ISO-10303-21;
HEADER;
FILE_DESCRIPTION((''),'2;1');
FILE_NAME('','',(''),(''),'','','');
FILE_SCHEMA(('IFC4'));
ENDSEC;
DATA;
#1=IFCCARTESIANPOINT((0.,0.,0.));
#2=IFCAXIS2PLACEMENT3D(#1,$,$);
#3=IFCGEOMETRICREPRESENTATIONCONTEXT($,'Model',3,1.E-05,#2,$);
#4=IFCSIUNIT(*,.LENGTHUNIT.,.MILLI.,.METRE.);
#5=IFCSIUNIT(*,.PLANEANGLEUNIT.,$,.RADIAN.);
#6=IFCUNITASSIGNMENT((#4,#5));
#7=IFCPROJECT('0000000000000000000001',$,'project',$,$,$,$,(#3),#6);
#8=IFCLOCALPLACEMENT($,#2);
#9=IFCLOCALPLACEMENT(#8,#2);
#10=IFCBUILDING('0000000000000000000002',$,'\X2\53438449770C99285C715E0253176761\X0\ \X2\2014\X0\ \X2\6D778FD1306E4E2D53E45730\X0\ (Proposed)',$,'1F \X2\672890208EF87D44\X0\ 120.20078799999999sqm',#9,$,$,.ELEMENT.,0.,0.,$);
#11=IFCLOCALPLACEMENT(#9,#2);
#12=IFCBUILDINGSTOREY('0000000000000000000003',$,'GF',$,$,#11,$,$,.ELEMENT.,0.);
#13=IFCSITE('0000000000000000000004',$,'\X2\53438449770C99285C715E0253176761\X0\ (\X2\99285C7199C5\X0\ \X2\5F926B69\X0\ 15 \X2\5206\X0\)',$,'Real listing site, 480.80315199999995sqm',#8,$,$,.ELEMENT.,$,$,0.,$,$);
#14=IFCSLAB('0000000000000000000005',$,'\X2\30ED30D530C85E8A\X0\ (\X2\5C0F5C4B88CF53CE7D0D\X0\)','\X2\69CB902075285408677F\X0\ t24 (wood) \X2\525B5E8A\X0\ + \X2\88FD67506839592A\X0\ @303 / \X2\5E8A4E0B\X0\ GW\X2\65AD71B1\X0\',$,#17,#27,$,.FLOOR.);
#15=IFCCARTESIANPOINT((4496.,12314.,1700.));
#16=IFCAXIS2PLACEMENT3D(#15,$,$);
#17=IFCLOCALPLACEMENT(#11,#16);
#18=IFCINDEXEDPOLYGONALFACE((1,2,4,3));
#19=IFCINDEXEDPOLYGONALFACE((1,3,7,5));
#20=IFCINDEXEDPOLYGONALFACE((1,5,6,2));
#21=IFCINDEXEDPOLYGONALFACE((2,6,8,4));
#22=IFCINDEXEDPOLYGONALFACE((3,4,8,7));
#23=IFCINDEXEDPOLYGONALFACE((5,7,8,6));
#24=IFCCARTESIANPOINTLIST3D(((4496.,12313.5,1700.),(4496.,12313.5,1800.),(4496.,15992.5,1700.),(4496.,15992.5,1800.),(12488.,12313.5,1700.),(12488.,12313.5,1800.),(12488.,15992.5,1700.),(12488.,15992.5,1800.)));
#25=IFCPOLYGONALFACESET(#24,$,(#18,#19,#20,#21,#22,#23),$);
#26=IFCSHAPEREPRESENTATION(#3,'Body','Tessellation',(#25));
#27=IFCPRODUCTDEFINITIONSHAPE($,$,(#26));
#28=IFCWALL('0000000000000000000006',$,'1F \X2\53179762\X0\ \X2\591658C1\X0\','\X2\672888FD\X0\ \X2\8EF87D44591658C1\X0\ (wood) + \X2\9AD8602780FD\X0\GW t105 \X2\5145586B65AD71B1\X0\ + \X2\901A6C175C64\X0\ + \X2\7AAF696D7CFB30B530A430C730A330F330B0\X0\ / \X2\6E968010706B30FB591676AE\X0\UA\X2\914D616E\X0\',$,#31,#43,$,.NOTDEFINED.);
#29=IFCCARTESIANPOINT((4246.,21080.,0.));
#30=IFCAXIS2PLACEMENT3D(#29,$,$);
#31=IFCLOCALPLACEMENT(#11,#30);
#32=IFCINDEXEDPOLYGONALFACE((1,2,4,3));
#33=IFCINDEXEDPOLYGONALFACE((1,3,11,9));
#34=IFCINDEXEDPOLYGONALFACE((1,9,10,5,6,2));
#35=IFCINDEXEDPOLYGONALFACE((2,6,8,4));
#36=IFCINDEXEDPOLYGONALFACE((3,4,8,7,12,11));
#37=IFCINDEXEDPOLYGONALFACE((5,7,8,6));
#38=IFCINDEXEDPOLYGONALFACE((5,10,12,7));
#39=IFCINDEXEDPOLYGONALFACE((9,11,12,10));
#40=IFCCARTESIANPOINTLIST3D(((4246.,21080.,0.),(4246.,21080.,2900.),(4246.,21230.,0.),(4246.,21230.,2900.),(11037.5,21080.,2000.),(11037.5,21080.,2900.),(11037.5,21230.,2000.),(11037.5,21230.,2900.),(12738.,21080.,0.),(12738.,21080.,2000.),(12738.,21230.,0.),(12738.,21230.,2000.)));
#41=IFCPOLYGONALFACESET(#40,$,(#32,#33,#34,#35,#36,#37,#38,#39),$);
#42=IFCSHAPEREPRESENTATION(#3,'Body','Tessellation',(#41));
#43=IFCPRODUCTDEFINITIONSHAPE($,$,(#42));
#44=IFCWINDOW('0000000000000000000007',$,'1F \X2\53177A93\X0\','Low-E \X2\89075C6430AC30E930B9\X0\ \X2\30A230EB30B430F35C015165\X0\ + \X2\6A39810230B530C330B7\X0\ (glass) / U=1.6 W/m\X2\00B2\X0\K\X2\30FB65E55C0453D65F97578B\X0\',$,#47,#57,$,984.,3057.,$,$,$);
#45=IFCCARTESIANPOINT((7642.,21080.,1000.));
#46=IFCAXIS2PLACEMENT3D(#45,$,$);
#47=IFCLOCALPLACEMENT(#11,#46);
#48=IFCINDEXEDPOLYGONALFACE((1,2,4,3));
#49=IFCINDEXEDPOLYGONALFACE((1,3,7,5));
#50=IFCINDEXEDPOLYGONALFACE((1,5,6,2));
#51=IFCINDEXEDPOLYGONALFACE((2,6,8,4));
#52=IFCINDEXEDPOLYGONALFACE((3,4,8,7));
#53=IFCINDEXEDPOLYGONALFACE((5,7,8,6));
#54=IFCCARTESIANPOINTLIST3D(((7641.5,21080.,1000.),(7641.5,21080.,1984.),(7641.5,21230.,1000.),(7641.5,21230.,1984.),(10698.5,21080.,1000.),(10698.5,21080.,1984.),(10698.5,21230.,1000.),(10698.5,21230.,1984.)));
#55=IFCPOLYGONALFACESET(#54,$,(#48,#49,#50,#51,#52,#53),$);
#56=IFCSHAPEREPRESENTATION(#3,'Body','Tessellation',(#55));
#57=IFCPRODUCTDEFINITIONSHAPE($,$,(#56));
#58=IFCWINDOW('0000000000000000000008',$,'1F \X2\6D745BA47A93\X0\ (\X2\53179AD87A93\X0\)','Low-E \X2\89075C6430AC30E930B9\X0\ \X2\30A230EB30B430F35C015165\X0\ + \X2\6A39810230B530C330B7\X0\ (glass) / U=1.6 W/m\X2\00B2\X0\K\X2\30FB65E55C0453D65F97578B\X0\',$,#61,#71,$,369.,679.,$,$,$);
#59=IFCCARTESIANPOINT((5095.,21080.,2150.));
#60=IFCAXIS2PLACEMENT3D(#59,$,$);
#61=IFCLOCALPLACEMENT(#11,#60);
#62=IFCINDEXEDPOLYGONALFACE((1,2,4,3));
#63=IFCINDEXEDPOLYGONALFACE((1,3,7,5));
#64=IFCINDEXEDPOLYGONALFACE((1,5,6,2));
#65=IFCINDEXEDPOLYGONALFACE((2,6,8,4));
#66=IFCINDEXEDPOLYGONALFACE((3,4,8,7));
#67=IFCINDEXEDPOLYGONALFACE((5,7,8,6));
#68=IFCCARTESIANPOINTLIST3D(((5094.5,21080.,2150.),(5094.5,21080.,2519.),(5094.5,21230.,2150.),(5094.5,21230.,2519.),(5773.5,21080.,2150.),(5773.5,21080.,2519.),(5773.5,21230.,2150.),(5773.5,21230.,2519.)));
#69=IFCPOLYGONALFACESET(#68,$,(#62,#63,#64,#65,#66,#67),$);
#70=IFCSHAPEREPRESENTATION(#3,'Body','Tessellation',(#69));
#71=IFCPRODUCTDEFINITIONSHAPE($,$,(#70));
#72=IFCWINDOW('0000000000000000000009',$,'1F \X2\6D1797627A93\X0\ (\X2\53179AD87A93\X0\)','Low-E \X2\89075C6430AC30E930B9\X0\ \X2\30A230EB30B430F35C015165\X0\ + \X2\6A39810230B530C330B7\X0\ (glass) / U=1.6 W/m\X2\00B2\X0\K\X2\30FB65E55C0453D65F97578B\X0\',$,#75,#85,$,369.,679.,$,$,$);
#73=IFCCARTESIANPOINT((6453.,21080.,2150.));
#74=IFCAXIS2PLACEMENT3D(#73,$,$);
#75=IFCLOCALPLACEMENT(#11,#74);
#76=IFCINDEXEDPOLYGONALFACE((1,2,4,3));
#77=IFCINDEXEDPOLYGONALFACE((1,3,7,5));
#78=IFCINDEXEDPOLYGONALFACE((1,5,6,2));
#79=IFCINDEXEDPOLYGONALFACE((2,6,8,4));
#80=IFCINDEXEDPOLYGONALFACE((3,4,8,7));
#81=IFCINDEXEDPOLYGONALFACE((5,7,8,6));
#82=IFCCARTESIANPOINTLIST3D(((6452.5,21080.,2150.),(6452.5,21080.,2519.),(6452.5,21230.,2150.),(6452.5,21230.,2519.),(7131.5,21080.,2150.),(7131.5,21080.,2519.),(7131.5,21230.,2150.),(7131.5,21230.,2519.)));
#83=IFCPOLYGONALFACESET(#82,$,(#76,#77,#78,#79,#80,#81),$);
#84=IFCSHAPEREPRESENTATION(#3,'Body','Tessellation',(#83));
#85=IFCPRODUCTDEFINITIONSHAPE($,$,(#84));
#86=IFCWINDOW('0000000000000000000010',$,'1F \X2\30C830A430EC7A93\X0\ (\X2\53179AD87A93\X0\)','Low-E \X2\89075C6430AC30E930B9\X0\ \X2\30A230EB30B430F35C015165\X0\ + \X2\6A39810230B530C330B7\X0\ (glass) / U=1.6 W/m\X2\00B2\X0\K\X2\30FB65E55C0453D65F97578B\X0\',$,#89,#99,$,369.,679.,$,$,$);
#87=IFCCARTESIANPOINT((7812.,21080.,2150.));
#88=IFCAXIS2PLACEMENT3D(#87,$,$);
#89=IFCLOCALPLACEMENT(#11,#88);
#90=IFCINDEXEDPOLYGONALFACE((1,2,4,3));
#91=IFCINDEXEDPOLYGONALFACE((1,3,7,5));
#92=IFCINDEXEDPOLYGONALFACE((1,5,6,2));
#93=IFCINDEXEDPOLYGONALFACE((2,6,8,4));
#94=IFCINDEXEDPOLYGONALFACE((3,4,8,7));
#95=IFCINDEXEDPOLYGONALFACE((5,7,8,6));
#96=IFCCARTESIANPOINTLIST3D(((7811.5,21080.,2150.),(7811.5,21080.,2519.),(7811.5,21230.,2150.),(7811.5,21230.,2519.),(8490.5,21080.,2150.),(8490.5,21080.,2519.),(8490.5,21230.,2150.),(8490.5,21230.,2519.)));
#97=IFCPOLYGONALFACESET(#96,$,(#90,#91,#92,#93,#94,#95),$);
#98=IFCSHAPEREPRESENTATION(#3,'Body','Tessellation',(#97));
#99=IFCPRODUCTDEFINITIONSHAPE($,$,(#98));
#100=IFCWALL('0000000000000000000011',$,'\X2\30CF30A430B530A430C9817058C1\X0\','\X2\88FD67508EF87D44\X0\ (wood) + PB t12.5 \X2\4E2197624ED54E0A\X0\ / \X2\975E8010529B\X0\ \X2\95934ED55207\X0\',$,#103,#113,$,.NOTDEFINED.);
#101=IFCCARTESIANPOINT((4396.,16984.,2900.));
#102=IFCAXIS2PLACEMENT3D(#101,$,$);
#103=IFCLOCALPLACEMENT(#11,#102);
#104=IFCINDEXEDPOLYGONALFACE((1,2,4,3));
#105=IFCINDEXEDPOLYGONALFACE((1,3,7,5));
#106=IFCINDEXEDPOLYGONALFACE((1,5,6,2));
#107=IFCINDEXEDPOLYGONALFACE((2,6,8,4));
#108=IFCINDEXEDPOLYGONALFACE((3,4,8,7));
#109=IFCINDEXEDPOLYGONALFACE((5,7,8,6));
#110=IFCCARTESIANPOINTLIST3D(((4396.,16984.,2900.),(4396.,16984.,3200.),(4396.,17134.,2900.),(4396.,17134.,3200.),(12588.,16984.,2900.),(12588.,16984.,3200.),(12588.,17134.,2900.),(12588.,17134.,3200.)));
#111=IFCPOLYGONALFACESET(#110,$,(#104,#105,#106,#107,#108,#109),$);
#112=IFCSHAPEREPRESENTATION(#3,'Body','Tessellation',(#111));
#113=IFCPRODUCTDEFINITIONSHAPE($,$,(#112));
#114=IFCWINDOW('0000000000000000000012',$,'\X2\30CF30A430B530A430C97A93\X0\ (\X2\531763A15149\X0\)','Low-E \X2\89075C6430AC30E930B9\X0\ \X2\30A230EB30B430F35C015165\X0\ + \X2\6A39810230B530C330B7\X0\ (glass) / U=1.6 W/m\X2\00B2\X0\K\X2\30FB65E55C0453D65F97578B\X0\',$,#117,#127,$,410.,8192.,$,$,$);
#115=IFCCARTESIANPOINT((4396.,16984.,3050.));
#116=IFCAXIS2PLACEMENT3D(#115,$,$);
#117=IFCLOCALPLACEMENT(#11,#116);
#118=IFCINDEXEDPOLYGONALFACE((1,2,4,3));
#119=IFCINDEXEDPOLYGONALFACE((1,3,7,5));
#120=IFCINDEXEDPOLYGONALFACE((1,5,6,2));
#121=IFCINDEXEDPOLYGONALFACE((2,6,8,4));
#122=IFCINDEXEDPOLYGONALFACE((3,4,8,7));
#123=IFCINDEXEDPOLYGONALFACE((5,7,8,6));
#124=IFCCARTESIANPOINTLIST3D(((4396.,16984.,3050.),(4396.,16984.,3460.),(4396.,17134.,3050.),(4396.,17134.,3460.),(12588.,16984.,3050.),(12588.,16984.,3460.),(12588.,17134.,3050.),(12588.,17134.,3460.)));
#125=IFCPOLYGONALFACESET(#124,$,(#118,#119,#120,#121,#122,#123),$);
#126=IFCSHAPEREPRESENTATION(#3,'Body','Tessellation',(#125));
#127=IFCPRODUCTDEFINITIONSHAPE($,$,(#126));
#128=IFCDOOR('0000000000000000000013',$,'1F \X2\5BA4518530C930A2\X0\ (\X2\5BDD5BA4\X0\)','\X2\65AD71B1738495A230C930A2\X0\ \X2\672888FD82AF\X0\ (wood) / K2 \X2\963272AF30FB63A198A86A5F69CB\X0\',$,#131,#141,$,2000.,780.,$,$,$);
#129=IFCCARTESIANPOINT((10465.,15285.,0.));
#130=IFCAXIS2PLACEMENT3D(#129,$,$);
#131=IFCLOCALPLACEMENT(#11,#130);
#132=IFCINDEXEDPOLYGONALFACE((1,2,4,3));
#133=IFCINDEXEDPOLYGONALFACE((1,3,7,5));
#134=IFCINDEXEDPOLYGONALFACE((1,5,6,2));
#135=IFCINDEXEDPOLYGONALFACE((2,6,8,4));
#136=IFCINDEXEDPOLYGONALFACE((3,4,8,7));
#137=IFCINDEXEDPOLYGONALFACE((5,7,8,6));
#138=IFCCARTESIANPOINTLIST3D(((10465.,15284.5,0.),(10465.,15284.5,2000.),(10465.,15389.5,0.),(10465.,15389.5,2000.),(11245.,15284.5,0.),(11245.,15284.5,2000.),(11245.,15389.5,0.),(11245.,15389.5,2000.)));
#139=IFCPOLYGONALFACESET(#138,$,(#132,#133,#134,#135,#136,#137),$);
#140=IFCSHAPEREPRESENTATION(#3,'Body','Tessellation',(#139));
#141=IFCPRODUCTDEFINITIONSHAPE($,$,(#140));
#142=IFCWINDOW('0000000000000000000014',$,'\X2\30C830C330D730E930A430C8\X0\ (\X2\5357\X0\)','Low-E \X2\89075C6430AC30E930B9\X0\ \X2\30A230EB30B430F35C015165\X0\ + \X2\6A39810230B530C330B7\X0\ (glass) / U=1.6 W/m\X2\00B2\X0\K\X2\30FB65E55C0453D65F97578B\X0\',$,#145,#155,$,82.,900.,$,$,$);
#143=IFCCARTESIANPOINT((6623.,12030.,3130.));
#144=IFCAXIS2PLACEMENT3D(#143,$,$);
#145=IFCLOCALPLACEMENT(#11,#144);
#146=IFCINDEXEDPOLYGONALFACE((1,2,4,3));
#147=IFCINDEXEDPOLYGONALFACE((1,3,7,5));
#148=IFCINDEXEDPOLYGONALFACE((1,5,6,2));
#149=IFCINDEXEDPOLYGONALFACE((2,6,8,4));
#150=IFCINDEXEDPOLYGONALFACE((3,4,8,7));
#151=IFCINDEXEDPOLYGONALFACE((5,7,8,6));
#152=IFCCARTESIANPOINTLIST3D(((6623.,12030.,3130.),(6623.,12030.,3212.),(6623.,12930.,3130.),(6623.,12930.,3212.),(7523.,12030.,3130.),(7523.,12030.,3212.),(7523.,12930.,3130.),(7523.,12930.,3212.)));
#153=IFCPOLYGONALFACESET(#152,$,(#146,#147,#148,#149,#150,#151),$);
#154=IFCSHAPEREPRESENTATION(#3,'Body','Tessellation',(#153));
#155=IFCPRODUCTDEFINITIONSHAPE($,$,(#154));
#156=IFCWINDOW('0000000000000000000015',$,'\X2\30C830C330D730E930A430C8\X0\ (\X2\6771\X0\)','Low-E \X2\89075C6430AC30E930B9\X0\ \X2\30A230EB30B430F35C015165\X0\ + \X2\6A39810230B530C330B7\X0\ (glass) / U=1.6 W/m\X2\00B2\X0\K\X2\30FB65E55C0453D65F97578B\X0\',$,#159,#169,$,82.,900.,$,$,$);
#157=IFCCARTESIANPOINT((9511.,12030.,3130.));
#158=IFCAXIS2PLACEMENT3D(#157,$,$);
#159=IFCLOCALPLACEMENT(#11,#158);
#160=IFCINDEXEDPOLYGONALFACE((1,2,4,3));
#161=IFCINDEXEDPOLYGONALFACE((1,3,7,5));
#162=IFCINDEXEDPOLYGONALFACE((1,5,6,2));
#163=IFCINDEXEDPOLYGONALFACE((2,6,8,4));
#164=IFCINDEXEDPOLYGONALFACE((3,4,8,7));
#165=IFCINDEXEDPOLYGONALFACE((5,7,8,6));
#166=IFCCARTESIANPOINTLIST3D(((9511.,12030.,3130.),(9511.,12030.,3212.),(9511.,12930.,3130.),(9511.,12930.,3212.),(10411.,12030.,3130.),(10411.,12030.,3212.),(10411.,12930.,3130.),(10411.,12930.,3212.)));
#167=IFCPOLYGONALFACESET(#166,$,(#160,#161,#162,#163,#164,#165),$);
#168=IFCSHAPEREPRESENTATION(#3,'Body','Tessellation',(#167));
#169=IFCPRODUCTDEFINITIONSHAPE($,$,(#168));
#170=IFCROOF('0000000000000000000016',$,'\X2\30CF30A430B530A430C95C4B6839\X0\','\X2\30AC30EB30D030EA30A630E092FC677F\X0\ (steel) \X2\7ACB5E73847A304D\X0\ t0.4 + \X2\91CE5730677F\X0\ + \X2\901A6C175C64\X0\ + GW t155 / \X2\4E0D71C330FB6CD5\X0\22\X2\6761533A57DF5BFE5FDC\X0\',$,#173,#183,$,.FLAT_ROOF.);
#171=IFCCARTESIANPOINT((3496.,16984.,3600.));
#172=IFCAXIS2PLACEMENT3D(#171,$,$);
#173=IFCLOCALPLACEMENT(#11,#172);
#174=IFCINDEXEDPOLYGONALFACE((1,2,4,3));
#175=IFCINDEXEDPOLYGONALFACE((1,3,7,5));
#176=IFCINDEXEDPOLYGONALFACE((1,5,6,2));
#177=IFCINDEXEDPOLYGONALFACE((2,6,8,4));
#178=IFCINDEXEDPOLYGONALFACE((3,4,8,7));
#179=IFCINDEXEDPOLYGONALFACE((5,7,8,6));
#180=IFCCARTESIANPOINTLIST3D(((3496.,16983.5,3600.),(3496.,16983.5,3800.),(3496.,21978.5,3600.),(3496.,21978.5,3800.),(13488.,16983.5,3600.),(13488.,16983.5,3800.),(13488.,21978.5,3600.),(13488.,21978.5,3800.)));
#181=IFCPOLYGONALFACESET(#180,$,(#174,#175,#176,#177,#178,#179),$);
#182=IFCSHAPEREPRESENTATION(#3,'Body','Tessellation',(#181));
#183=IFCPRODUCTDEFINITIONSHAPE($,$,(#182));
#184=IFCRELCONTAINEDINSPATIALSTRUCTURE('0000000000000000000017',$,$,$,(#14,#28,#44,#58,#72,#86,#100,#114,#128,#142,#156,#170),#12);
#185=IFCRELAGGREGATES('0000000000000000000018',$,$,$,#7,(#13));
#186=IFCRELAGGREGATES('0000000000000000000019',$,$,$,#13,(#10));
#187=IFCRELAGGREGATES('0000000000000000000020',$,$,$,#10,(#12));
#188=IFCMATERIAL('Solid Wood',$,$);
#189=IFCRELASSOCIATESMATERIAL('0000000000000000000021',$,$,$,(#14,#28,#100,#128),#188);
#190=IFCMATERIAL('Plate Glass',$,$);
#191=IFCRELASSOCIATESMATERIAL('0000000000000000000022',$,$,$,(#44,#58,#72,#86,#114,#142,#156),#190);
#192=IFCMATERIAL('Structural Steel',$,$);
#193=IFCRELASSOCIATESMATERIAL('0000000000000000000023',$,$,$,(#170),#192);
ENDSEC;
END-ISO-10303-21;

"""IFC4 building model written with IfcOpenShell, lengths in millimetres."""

from ifc_helpers import new_model, si_unit, frame, frame_2d, origin, place, context, project, spatial, rectangle, extrude, material, element, fill, save


model = new_model("IFC4")

# Units and contexts
model_context = context("Model", 3, precision=1e-05, world=origin())
ifc_project = project(units=[si_unit("LENGTHUNIT", "METRE", prefix="MILLI"), si_unit("PLANEANGLEUNIT", "RADIAN")], contexts=[model_context])

# Site, building, storey
site_placement = place(None, origin())
site = spatial("IfcSite", under=ifc_project, at=site_placement, Name="千葉県館山市北条 (館山駅 徒歩 15 分)", ObjectType="Real listing site, 480.80315199999995sqm", CompositionType="ELEMENT", RefElevation=0.0)
building_placement = place(site_placement, origin())
building = spatial("IfcBuilding", under=site, at=building_placement, Name="千葉県館山市北条 — 海近の中古地 (Proposed)", ObjectType="1F 木造軸組 120.20078799999999sqm", CompositionType="ELEMENT", ElevationOfRefHeight=0.0, ElevationOfTerrain=0.0)
storey_placement = place(building_placement, origin())
storey = spatial("IfcBuildingStorey", under=building, at=storey_placement, Name="GF", CompositionType="ELEMENT", Elevation=0.0)

# Slab
ifc_material_1 = material(Name="Solid Wood")
slab_placement = place(storey_placement, frame((4496.0, 12314.0, 1700.0)))
element("IfcSlab", 1, at=slab_placement, inside=storey, material=ifc_material_1, Name="ロフト床 (小屋裏収納)", Description="構造用合板 t24 (wood) 剛床 + 製材根太 @303 / 床下 GW断熱", PredefinedType="FLOOR", context=model_context, shape_type="SweptSolid", body=[
    extrude(rectangle(XDim=7992.0, YDim=3679.0, at=frame_2d((3996.0, 1839.0))), frame((4496.0, 12314.0, 1700.0)), (0.0, 0.0, 1.0), 100.0),
])

# Wall, openings, windows
wall_1_placement = place(storey_placement, frame((4246.0, 21080.0, 0.0)))
wall_1 = element("IfcWall", 2, at=wall_1_placement, inside=storey, material=ifc_material_1, Name="1F 北面 外壁", Description="木製 軸組外壁 (wood) + 高性能GW t105 充填断熱 + 通気層 + 窯業系サイディング / 準耐火・外皮UA配慮", PredefinedType="NOTDEFINED", context=model_context, shape_type="SweptSolid", body=[
    extrude(rectangle(XDim=8492.0, YDim=150.0, at=frame_2d((4246.0, 75.0))), frame((4246.0, 21080.0, 0.0)), (0.0, 0.0, 1.0), 2900.0),
])
opening_1_placement = place(storey_placement, frame((7642.0, 21080.0, 1000.0)))
opening_1 = element("IfcOpeningElement", 3, at=opening_1_placement, cuts=wall_1, PredefinedType="NOTDEFINED", context=model_context, shape_type="SweptSolid", body=[
    extrude(rectangle(XDim=3057.0, YDim=150.0, at=frame_2d((1528.0, 75.0))), frame((7642.0, 21080.0, 1000.0)), (0.0, 0.0, 1.0), 984.0),
])
opening_2_placement = place(storey_placement, frame((5095.0, 21080.0, 2150.0)))
opening_2 = element("IfcOpeningElement", 4, at=opening_2_placement, cuts=wall_1, PredefinedType="NOTDEFINED", context=model_context, shape_type="SweptSolid", body=[
    extrude(rectangle(XDim=679.0, YDim=150.0, at=frame_2d((339.0, 75.0))), frame((5095.0, 21080.0, 2150.0)), (0.0, 0.0, 1.0), 369.0),
])
opening_3_placement = place(storey_placement, frame((6453.0, 21080.0, 2150.0)))
opening_3 = element("IfcOpeningElement", 5, at=opening_3_placement, cuts=wall_1, PredefinedType="NOTDEFINED", context=model_context, shape_type="SweptSolid", body=[
    extrude(rectangle(XDim=679.0, YDim=150.0, at=frame_2d((339.0, 75.0))), frame((6453.0, 21080.0, 2150.0)), (0.0, 0.0, 1.0), 369.0),
])
opening_4_placement = place(storey_placement, frame((7812.0, 21080.0, 2150.0)))
opening_4 = element("IfcOpeningElement", 6, at=opening_4_placement, cuts=wall_1, PredefinedType="NOTDEFINED", context=model_context, shape_type="SweptSolid", body=[
    extrude(rectangle(XDim=679.0, YDim=150.0, at=frame_2d((339.0, 75.0))), frame((7812.0, 21080.0, 2150.0)), (0.0, 0.0, 1.0), 369.0),
])
ifc_material_2 = material(Name="Plate Glass")
window_1_placement = place(storey_placement, frame((7642.0, 21080.0, 1000.0)))
window_1 = element("IfcWindow", 7, at=window_1_placement, inside=storey, material=ifc_material_2, Name="1F 北窓", Description="Low-E 複層ガラス アルゴン封入 + 樹脂サッシ (glass) / U=1.6 W/m²K・日射取得型", OverallHeight=984.0, OverallWidth=3057.0, context=model_context, shape_type="SweptSolid", body=[
    extrude(rectangle(XDim=3057.0, YDim=150.0, at=frame_2d((1528.0, 75.0))), frame((7642.0, 21080.0, 1000.0)), (0.0, 0.0, 1.0), 984.0),
])
fill(opening_1, window_1)
window_2_placement = place(storey_placement, frame((5095.0, 21080.0, 2150.0)))
window_2 = element("IfcWindow", 8, at=window_2_placement, inside=storey, material=ifc_material_2, Name="1F 浴室窓 (北高窓)", Description="Low-E 複層ガラス アルゴン封入 + 樹脂サッシ (glass) / U=1.6 W/m²K・日射取得型", OverallHeight=369.0, OverallWidth=679.0, context=model_context, shape_type="SweptSolid", body=[
    extrude(rectangle(XDim=679.0, YDim=150.0, at=frame_2d((339.0, 75.0))), frame((5095.0, 21080.0, 2150.0)), (0.0, 0.0, 1.0), 369.0),
])
fill(opening_2, window_2)
window_3_placement = place(storey_placement, frame((6453.0, 21080.0, 2150.0)))
window_3 = element("IfcWindow", 9, at=window_3_placement, inside=storey, material=ifc_material_2, Name="1F 洗面窓 (北高窓)", Description="Low-E 複層ガラス アルゴン封入 + 樹脂サッシ (glass) / U=1.6 W/m²K・日射取得型", OverallHeight=369.0, OverallWidth=679.0, context=model_context, shape_type="SweptSolid", body=[
    extrude(rectangle(XDim=679.0, YDim=150.0, at=frame_2d((339.0, 75.0))), frame((6453.0, 21080.0, 2150.0)), (0.0, 0.0, 1.0), 369.0),
])
fill(opening_3, window_3)
window_4_placement = place(storey_placement, frame((7812.0, 21080.0, 2150.0)))
window_4 = element("IfcWindow", 10, at=window_4_placement, inside=storey, material=ifc_material_2, Name="1F トイレ窓 (北高窓)", Description="Low-E 複層ガラス アルゴン封入 + 樹脂サッシ (glass) / U=1.6 W/m²K・日射取得型", OverallHeight=369.0, OverallWidth=679.0, context=model_context, shape_type="SweptSolid", body=[
    extrude(rectangle(XDim=679.0, YDim=150.0, at=frame_2d((339.0, 75.0))), frame((7812.0, 21080.0, 2150.0)), (0.0, 0.0, 1.0), 369.0),
])
fill(opening_4, window_4)

# Wall, opening, window
wall_2_placement = place(storey_placement, frame((4396.0, 16984.0, 2900.0)))
wall_2 = element("IfcWall", 11, at=wall_2_placement, inside=storey, material=ifc_material_1, Name="ハイサイド腰壁", Description="製材軸組 (wood) + PB t12.5 両面仕上 / 非耐力 間仕切", PredefinedType="NOTDEFINED", context=model_context, shape_type="SweptSolid", body=[
    extrude(rectangle(XDim=8192.0, YDim=150.0, at=frame_2d((4096.0, 75.0))), frame((4396.0, 16984.0, 2900.0)), (0.0, 0.0, 1.0), 700.0),
])
opening_5_placement = place(storey_placement, frame((4396.0, 16984.0, 3050.0)))
opening_5 = element("IfcOpeningElement", 12, at=opening_5_placement, cuts=wall_2, PredefinedType="NOTDEFINED", context=model_context, shape_type="SweptSolid", body=[
    extrude(rectangle(XDim=8192.0, YDim=150.0, at=frame_2d((4096.0, 75.0))), frame((4396.0, 16984.0, 3050.0)), (0.0, 0.0, 1.0), 410.0),
])
window_5_placement = place(storey_placement, frame((4396.0, 16984.0, 3050.0)))
window_5 = element("IfcWindow", 13, at=window_5_placement, inside=storey, material=ifc_material_2, Name="ハイサイド窓 (北採光)", Description="Low-E 複層ガラス アルゴン封入 + 樹脂サッシ (glass) / U=1.6 W/m²K・日射取得型", OverallHeight=410.0, OverallWidth=8192.0, context=model_context, shape_type="SweptSolid", body=[
    extrude(rectangle(XDim=8192.0, YDim=150.0, at=frame_2d((4096.0, 75.0))), frame((4396.0, 16984.0, 3050.0)), (0.0, 0.0, 1.0), 410.0),
])
fill(opening_5, window_5)

# Door
door_1_placement = place(storey_placement, frame((10465.0, 15285.0, 0.0)))
element("IfcDoor", 14, at=door_1_placement, inside=storey, material=ifc_material_1, Name="1F 室内ドア (寝室)", Description="断熱玄関ドア 木製芯 (wood) / K2 防犯・採風機構", OverallHeight=2000.0, OverallWidth=780.0, context=model_context, shape_type="SweptSolid", body=[
    extrude(rectangle(XDim=780.0, YDim=105.0, at=frame_2d((390.0, 52.0))), frame((10465.0, 15285.0, 0.0)), (0.0, 0.0, 1.0), 2000.0),
])

# Windows
window_6_placement = place(storey_placement, frame((6623.0, 12030.0, 3130.0)))
element("IfcWindow", 15, at=window_6_placement, inside=storey, material=ifc_material_2, Name="トップライト (南)", Description="Low-E 複層ガラス アルゴン封入 + 樹脂サッシ (glass) / U=1.6 W/m²K・日射取得型", OverallHeight=82.0, OverallWidth=900.0, context=model_context, shape_type="SweptSolid", body=[
    extrude(rectangle(XDim=900.0, YDim=900.0, at=frame_2d((450.0, 450.0))), frame((6623.0, 12030.0, 3130.0)), (0.0, 0.0, 1.0), 82.0),
])
window_7_placement = place(storey_placement, frame((9511.0, 12030.0, 3130.0)))
element("IfcWindow", 16, at=window_7_placement, inside=storey, material=ifc_material_2, Name="トップライト (東)", Description="Low-E 複層ガラス アルゴン封入 + 樹脂サッシ (glass) / U=1.6 W/m²K・日射取得型", OverallHeight=82.0, OverallWidth=900.0, context=model_context, shape_type="SweptSolid", body=[
    extrude(rectangle(XDim=900.0, YDim=900.0, at=frame_2d((450.0, 450.0))), frame((9511.0, 12030.0, 3130.0)), (0.0, 0.0, 1.0), 82.0),
])

# Roof
ifc_material_3 = material(Name="Structural Steel")
roof_placement = place(storey_placement, frame((3496.0, 16984.0, 3600.0)))
element("IfcRoof", 17, at=roof_placement, inside=storey, material=ifc_material_3, Name="ハイサイド屋根", Description="ガルバリウム鋼板 (steel) 立平葺き t0.4 + 野地板 + 通気層 + GW t155 / 不燃・法22条区域対応", PredefinedType="FLAT_ROOF", context=model_context, shape_type="SweptSolid", body=[
    extrude(rectangle(XDim=9992.0, YDim=4995.0, at=frame_2d((4996.0, 2497.0))), frame((3496.0, 16984.0, 3600.0)), (0.0, 0.0, 1.0), 200.0),
])

save(model, "model.ifc")
